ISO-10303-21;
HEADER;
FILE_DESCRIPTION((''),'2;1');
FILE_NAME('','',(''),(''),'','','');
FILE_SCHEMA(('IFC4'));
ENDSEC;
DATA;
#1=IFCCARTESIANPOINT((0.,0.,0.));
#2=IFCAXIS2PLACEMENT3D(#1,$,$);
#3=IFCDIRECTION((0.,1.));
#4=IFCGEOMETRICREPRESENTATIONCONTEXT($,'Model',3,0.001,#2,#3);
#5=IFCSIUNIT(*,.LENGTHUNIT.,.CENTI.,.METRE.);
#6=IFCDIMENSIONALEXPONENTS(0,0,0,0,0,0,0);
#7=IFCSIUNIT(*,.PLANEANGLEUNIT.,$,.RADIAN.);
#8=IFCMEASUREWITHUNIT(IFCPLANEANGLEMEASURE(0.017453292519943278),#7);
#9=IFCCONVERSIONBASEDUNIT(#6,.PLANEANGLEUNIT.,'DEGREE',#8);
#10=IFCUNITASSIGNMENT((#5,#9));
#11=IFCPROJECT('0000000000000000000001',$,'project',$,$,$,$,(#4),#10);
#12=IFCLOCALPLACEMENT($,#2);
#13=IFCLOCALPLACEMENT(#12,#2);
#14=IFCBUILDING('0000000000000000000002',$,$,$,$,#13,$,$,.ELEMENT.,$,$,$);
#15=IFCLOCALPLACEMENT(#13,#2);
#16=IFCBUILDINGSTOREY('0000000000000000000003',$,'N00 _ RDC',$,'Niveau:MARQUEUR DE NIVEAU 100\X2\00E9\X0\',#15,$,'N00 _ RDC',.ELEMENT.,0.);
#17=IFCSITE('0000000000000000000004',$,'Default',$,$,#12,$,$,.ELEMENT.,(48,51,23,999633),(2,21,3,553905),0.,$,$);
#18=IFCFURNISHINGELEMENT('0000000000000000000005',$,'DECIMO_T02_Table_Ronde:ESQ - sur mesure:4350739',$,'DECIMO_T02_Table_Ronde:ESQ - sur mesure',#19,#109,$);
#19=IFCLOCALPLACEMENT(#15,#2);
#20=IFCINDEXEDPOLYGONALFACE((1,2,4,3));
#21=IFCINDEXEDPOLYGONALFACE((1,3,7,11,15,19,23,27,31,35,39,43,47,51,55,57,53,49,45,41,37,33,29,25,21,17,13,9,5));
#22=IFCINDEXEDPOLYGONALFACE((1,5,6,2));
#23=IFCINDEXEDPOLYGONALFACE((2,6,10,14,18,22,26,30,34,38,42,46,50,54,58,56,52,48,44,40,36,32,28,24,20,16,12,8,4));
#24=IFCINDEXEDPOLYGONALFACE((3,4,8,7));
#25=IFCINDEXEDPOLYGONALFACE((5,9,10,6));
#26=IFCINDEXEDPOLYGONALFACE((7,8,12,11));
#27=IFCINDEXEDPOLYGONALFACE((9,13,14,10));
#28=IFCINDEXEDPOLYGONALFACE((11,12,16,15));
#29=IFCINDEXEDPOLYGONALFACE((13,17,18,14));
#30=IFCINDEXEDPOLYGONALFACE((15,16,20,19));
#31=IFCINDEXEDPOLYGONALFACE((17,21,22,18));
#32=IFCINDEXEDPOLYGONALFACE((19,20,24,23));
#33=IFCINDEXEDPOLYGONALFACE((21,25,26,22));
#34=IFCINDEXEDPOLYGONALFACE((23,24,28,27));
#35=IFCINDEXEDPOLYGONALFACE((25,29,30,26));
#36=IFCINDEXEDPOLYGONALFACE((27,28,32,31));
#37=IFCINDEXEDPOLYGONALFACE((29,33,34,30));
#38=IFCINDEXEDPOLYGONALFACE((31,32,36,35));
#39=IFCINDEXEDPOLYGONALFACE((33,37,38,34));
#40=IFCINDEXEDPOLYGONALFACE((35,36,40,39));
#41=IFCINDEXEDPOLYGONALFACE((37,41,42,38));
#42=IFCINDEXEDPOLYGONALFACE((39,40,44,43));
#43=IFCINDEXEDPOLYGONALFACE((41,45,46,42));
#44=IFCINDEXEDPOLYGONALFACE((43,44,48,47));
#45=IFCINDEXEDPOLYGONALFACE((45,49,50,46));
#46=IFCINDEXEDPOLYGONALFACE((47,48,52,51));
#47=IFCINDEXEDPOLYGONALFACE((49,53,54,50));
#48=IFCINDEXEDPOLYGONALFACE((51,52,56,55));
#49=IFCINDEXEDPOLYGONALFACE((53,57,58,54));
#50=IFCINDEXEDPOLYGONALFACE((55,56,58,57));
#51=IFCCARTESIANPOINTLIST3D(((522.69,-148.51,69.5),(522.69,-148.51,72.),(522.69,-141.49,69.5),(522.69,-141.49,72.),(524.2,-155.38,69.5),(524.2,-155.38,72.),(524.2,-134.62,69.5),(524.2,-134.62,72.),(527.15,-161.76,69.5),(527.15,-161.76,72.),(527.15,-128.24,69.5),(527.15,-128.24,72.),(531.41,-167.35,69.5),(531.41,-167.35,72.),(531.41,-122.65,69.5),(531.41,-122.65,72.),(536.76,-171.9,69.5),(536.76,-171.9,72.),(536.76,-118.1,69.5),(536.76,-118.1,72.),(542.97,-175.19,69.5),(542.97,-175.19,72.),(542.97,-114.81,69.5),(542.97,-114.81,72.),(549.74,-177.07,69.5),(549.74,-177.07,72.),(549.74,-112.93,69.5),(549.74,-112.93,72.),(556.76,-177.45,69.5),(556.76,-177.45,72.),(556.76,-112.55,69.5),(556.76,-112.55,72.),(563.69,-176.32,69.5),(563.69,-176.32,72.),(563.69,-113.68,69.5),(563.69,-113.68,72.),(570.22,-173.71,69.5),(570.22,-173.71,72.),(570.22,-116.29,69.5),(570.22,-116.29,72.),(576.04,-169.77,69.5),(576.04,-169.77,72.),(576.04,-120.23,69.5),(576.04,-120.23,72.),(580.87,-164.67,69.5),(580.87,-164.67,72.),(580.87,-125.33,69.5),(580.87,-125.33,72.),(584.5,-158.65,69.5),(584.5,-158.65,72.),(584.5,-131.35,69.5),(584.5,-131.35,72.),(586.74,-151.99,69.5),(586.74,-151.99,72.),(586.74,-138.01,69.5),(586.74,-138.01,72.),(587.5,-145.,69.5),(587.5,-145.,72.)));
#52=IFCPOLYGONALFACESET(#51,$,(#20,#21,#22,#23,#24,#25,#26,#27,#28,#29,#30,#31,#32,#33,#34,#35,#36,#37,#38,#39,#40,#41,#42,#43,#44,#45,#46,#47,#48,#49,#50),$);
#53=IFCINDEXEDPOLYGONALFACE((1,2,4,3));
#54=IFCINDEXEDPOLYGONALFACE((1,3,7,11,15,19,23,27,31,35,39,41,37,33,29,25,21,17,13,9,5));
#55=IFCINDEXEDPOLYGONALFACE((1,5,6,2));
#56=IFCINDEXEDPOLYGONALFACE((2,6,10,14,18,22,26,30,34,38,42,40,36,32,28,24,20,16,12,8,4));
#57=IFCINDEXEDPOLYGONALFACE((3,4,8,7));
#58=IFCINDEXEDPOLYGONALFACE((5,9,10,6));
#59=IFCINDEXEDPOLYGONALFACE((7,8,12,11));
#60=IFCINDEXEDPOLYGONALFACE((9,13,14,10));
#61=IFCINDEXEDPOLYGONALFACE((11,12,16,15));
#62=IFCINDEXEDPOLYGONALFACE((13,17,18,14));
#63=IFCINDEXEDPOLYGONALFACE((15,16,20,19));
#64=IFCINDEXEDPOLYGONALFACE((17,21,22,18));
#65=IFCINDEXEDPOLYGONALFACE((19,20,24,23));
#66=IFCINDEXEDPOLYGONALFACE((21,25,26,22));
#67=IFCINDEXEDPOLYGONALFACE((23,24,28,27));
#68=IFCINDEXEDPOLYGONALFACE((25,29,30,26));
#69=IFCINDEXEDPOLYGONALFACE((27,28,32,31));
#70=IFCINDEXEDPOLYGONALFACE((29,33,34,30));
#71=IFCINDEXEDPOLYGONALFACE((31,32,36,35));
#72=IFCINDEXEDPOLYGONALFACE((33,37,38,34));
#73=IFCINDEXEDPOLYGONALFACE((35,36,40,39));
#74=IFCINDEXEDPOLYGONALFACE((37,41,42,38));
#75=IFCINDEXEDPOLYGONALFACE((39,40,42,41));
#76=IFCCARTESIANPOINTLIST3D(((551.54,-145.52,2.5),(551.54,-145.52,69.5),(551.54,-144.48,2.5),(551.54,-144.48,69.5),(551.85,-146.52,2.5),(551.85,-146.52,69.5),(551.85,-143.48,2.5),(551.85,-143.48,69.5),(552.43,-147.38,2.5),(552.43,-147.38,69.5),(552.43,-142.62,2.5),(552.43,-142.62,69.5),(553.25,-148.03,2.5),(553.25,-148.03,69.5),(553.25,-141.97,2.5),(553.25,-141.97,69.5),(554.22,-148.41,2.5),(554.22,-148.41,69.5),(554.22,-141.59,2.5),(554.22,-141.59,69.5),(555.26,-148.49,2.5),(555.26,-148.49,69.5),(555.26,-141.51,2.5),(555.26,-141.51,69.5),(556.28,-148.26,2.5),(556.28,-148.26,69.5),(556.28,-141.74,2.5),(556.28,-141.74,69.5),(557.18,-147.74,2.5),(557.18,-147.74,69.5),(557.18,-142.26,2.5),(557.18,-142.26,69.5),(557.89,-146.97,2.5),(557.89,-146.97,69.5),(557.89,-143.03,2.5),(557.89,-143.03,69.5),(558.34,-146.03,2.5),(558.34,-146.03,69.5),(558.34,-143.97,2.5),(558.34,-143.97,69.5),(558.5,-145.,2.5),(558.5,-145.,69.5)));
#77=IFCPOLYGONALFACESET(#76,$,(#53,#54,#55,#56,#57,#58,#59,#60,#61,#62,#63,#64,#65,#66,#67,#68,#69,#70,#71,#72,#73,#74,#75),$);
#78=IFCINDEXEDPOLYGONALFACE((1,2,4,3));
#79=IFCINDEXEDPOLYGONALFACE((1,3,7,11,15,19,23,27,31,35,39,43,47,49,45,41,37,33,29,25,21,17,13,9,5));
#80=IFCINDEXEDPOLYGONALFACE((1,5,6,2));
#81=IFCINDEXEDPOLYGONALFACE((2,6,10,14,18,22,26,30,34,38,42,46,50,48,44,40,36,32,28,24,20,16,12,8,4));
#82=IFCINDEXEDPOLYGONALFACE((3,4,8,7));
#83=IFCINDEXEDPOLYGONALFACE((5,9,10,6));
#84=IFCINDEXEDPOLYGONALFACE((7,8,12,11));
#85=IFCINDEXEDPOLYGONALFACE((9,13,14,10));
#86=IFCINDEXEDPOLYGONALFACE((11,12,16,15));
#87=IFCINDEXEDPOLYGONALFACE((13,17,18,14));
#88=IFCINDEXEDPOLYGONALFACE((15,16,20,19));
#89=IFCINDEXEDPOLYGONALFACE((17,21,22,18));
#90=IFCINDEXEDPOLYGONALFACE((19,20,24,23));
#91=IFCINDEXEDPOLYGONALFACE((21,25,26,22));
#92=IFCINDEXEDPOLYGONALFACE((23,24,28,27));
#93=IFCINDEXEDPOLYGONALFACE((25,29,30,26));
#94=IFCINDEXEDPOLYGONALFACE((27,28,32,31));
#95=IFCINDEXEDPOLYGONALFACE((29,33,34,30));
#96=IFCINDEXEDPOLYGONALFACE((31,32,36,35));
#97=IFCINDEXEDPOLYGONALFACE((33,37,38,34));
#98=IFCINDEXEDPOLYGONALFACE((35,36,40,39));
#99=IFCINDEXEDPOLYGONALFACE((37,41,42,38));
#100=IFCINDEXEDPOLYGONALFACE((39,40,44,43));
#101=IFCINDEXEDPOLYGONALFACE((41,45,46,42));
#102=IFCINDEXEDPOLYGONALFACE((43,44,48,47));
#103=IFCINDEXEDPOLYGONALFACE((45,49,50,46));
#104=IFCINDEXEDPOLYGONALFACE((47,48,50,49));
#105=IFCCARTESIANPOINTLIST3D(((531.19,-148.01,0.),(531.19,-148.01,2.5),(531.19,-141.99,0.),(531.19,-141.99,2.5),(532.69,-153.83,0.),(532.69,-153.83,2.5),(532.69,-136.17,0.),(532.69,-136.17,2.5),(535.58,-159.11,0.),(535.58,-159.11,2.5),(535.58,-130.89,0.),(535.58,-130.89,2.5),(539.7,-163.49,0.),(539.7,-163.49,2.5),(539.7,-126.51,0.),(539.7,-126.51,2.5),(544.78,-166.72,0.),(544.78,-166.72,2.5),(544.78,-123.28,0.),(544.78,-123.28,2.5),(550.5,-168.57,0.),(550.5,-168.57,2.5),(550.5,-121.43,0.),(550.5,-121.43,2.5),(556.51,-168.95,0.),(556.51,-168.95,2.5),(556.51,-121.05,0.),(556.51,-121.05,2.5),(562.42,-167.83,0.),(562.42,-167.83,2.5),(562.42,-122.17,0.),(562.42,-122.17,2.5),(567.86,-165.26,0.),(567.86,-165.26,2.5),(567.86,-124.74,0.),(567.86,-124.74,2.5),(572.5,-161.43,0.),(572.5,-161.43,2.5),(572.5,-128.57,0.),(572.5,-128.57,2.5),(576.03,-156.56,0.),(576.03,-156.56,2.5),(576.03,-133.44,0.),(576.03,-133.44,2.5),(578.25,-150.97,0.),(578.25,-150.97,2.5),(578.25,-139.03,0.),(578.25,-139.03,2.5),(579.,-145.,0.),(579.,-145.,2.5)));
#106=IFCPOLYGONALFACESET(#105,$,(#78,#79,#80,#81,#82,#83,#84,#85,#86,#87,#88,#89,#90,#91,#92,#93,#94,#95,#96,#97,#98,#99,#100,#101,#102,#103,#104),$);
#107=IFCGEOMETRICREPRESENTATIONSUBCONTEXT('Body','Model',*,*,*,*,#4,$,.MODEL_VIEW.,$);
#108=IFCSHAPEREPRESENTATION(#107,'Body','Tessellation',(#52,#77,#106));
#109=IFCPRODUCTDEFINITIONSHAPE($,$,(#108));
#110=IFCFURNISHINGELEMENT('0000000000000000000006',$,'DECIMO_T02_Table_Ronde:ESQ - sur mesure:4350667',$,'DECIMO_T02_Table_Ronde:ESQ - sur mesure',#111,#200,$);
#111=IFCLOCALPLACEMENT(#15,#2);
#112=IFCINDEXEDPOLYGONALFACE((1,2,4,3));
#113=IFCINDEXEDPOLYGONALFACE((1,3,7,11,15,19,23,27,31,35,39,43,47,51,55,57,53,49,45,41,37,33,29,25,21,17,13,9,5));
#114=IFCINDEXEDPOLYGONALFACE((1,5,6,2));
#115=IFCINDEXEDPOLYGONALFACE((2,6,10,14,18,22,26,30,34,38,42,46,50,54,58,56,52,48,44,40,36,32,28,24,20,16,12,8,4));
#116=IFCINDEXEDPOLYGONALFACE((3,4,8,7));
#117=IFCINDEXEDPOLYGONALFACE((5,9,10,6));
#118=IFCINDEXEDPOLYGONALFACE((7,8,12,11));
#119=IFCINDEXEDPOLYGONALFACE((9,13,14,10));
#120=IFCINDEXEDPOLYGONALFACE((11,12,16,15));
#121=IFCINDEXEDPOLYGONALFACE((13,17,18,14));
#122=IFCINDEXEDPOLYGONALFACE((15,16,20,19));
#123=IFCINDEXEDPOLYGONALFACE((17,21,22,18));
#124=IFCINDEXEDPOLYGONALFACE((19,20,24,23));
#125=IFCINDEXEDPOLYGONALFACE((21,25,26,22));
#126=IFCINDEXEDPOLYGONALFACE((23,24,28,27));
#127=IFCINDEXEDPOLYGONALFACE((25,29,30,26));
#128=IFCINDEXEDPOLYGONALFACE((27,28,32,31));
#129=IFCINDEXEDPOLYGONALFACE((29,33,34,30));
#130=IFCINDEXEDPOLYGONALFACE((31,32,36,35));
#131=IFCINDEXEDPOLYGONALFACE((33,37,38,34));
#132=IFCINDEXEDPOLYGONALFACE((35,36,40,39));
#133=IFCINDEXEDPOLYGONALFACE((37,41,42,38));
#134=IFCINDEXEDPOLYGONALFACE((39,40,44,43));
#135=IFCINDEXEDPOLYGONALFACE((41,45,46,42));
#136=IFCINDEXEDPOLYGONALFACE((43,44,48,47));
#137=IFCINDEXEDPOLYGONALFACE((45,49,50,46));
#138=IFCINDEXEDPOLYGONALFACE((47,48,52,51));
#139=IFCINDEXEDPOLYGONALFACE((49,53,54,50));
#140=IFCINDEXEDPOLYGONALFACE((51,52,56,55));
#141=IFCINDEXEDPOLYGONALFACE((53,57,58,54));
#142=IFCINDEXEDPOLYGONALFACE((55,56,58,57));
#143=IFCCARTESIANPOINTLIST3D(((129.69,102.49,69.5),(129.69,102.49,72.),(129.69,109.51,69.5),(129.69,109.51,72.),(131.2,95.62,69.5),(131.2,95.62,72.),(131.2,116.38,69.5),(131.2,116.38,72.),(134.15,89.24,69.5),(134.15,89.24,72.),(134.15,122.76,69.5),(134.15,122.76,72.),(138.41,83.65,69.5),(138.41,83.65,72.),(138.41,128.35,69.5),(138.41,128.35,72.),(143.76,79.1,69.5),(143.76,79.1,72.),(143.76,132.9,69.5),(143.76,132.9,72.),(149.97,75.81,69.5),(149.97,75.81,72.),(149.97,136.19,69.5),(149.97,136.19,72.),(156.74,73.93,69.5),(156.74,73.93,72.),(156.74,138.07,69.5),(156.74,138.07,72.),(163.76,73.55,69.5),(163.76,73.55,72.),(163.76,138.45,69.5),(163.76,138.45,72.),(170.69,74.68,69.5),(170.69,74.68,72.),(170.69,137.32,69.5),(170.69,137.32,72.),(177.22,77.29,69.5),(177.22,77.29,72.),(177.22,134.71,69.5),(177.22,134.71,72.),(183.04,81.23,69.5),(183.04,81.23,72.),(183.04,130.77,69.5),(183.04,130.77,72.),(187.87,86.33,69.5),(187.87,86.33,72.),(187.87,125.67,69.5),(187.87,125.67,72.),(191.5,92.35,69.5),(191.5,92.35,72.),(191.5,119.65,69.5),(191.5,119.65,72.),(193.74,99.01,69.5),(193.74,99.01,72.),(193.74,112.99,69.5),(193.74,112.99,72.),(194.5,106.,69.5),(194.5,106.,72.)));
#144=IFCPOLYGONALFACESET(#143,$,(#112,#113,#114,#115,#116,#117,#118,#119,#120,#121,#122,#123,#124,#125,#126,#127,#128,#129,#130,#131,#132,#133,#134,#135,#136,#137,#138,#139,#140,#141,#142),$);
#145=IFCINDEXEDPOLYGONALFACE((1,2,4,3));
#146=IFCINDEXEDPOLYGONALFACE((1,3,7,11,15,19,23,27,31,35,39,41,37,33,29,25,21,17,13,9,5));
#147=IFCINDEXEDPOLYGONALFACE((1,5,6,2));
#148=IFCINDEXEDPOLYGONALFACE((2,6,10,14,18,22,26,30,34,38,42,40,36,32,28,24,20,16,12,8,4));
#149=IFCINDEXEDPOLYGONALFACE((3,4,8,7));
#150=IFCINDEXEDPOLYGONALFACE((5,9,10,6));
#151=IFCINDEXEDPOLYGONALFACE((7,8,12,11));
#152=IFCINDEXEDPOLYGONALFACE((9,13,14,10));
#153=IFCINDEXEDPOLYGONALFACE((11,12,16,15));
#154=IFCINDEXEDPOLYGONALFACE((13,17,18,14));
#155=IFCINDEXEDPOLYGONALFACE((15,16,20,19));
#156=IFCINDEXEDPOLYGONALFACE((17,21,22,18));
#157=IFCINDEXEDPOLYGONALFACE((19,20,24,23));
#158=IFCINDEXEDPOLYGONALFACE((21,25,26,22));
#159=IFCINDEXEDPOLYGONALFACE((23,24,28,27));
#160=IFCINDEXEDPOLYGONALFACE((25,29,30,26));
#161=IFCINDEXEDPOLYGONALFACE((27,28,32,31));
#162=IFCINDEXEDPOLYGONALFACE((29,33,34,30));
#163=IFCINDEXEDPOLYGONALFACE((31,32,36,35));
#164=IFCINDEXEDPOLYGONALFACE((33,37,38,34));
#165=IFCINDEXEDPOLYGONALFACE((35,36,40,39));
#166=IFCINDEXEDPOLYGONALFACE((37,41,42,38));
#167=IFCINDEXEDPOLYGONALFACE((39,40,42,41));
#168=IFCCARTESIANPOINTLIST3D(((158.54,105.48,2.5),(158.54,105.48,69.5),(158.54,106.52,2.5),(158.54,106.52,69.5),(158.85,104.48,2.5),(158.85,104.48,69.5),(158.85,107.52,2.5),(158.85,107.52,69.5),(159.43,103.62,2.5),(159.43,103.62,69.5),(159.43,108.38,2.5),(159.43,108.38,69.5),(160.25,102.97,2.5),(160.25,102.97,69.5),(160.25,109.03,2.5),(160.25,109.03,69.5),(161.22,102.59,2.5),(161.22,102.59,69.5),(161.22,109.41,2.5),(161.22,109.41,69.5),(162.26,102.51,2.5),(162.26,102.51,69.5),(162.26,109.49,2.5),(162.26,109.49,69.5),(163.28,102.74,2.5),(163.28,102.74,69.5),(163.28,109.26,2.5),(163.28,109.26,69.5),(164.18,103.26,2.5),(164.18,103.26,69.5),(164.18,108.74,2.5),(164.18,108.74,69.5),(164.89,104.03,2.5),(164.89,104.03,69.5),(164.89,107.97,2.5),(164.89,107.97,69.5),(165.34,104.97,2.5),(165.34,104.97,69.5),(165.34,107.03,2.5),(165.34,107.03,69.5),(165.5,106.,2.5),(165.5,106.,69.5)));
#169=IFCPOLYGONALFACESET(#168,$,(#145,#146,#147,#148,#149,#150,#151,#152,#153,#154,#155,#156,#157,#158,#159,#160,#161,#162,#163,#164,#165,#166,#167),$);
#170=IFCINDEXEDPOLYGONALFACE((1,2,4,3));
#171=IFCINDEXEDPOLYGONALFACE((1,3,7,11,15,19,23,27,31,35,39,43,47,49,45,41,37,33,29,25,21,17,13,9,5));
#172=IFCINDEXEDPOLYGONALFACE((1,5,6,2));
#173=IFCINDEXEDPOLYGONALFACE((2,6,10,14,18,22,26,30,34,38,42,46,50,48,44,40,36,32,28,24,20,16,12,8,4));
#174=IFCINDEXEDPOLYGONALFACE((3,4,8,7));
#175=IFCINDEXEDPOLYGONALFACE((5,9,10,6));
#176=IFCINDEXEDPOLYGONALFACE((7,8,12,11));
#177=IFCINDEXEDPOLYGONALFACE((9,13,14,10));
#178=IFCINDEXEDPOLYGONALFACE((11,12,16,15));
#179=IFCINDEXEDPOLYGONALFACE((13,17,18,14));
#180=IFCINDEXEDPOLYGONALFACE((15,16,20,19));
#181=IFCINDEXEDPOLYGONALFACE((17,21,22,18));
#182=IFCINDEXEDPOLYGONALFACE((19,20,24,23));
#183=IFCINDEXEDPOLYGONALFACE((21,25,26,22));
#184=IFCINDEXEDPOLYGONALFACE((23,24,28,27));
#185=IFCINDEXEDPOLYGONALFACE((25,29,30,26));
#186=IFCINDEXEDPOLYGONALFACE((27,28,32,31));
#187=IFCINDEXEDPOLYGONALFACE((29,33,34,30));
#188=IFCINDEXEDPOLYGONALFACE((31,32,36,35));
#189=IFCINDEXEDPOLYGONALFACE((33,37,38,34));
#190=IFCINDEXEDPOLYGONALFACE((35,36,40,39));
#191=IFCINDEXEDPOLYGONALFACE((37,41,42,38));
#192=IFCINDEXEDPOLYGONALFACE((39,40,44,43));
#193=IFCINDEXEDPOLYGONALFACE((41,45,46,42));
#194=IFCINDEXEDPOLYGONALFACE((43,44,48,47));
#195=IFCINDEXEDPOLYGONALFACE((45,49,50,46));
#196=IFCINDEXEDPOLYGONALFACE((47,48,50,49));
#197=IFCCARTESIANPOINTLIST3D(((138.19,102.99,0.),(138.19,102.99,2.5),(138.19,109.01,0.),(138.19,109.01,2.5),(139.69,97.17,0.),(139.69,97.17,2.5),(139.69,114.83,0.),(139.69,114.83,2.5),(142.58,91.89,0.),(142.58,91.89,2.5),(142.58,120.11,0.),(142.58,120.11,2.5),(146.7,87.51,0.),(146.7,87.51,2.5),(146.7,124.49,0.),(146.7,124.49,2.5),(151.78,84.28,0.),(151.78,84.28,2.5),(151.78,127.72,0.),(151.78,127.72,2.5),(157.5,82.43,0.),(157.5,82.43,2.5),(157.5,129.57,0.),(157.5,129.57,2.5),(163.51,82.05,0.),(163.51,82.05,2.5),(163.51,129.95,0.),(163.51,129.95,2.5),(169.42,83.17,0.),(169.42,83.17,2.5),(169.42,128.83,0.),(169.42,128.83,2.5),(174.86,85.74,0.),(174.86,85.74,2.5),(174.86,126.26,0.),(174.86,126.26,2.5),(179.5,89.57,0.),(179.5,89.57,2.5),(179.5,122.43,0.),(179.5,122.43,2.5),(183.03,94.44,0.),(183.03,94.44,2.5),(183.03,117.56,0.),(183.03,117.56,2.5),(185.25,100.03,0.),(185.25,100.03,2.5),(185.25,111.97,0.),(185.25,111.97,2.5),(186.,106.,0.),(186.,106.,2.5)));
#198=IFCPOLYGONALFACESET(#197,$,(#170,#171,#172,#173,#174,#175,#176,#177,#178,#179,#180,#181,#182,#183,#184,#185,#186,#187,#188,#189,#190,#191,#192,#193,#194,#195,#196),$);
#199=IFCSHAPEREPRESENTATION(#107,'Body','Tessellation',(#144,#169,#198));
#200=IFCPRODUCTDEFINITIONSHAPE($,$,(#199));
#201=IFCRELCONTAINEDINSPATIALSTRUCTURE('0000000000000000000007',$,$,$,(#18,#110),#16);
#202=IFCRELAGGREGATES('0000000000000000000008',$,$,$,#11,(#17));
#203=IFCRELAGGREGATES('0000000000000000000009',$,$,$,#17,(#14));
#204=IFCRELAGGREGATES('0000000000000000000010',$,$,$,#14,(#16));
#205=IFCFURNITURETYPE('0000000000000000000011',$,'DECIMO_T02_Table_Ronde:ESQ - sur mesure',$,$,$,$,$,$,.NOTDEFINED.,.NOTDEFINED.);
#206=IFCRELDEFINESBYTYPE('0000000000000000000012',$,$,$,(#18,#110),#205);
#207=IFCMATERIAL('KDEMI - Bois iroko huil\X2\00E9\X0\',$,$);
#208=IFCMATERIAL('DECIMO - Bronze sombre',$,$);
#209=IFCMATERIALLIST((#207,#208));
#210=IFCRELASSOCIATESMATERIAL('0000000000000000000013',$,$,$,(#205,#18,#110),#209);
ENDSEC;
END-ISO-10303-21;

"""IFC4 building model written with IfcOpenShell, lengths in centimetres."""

from ifc_helpers import new_model, entity, si_unit, converted_unit, direction, frame, frame_2d, origin, place, context, subcontext, project, spatial, circle, extrude, source, transform, mapped, material, material_list, type_object, type_shapes, element, save


model = new_model("IFC4")

# Units and contexts
model_context = context("Model", 3, precision=0.001, world=origin(), true_north=direction((0.0, 1.0)))
body_context = subcontext(model_context, "Body", "Model", "MODEL_VIEW")
ifc_project = project(units=[si_unit("LENGTHUNIT", "METRE", prefix="CENTI"), converted_unit("PLANEANGLEUNIT", "DEGREE", entity("IfcPlaneAngleMeasure", 0.017453292519943278), si_unit("PLANEANGLEUNIT", "RADIAN"), dimensions=[0, 0, 0, 0, 0, 0, 0])], contexts=[model_context])

# Site, building, storey
site_placement = place(None, origin())
site = spatial("IfcSite", under=ifc_project, at=site_placement, Name="Default", CompositionType="ELEMENT", RefLatitude=(48, 51, 23, 999633), RefLongitude=(2, 21, 3, 553905), RefElevation=0.0)
building_placement = place(site_placement, origin())
building = spatial("IfcBuilding", under=site, at=building_placement, CompositionType="ELEMENT")
storey_placement = place(building_placement, origin())
storey = spatial("IfcBuildingStorey", under=building, at=storey_placement, Name="N00 _ RDC", ObjectType="Niveau:MARQUEUR DE NIVEAU 100é", LongName="N00 _ RDC", CompositionType="ELEMENT", Elevation=0.0)

# Furnishing elements
ifc_material_1 = material(Name="KDEMI - Bois iroko huilé")
ifc_material_2 = material(Name="DECIMO - Bronze sombre")
ifc_material_list_1 = material_list([ifc_material_1, ifc_material_2])
furniture_type_1 = type_object("IfcFurnitureType", Name="DECIMO_T02_Table_Ronde:ESQ - sur mesure", AssemblyPlace="NOTDEFINED", material=ifc_material_list_1)
shared_shape_1 = source(origin(), body_context, "Body", "SweptSolid", [
    extrude(circle(Radius=32.5, at=frame_2d((0.0, 0.0), x_axis=(1.0, 0.0))), frame((0.0, 0.0, 69.5)), (0.0, 0.0, 1.0), 2.5),
    extrude(circle(Radius=3.5, at=frame_2d((0.0, 0.0), x_axis=(1.0, 0.0))), frame((0.0, 0.0, 2.5)), (0.0, 0.0, 1.0), 67.0),
    extrude(circle(Radius=24.0, at=frame_2d((0.0, 0.0), x_axis=(1.0, 0.0))), origin(), (0.0, 0.0, 1.0), 2.5),
])
type_shapes(furniture_type_1, [shared_shape_1])
furnishing_1_placement = place(storey_placement, frame((555.0, -145.0, 0.0), z_axis=(0.0, 0.0, 1.0), x_axis=(1.0, 0.0, 0.0)))
element("IfcFurnishingElement", 1, at=furnishing_1_placement, inside=storey, type_object=furniture_type_1, material=ifc_material_list_1, Name="DECIMO_T02_Table_Ronde:ESQ - sur mesure:4350739", ObjectType="DECIMO_T02_Table_Ronde:ESQ - sur mesure", context=body_context, shape_type="MappedRepresentation", body=[
    mapped(shared_shape_1, transform((0.0, 0.0, 0.0), scale=1.0)),
])
for number, where, name in (
    (2, (162.0, 106.0, 0.0), "DECIMO_T02_Table_Ronde:ESQ - sur mesure:4350667"),
):
    element("IfcFurnishingElement", number, at=place(storey_placement, frame(where)), inside=storey, type_object=furniture_type_1, material=ifc_material_list_1, Name=name, ObjectType="DECIMO_T02_Table_Ronde:ESQ - sur mesure", context=body_context, shape_type="MappedRepresentation", body=[
        mapped(shared_shape_1, transform((0.0, 0.0, 0.0), scale=1.0)),
    ])

save(model, "model.ifc")
